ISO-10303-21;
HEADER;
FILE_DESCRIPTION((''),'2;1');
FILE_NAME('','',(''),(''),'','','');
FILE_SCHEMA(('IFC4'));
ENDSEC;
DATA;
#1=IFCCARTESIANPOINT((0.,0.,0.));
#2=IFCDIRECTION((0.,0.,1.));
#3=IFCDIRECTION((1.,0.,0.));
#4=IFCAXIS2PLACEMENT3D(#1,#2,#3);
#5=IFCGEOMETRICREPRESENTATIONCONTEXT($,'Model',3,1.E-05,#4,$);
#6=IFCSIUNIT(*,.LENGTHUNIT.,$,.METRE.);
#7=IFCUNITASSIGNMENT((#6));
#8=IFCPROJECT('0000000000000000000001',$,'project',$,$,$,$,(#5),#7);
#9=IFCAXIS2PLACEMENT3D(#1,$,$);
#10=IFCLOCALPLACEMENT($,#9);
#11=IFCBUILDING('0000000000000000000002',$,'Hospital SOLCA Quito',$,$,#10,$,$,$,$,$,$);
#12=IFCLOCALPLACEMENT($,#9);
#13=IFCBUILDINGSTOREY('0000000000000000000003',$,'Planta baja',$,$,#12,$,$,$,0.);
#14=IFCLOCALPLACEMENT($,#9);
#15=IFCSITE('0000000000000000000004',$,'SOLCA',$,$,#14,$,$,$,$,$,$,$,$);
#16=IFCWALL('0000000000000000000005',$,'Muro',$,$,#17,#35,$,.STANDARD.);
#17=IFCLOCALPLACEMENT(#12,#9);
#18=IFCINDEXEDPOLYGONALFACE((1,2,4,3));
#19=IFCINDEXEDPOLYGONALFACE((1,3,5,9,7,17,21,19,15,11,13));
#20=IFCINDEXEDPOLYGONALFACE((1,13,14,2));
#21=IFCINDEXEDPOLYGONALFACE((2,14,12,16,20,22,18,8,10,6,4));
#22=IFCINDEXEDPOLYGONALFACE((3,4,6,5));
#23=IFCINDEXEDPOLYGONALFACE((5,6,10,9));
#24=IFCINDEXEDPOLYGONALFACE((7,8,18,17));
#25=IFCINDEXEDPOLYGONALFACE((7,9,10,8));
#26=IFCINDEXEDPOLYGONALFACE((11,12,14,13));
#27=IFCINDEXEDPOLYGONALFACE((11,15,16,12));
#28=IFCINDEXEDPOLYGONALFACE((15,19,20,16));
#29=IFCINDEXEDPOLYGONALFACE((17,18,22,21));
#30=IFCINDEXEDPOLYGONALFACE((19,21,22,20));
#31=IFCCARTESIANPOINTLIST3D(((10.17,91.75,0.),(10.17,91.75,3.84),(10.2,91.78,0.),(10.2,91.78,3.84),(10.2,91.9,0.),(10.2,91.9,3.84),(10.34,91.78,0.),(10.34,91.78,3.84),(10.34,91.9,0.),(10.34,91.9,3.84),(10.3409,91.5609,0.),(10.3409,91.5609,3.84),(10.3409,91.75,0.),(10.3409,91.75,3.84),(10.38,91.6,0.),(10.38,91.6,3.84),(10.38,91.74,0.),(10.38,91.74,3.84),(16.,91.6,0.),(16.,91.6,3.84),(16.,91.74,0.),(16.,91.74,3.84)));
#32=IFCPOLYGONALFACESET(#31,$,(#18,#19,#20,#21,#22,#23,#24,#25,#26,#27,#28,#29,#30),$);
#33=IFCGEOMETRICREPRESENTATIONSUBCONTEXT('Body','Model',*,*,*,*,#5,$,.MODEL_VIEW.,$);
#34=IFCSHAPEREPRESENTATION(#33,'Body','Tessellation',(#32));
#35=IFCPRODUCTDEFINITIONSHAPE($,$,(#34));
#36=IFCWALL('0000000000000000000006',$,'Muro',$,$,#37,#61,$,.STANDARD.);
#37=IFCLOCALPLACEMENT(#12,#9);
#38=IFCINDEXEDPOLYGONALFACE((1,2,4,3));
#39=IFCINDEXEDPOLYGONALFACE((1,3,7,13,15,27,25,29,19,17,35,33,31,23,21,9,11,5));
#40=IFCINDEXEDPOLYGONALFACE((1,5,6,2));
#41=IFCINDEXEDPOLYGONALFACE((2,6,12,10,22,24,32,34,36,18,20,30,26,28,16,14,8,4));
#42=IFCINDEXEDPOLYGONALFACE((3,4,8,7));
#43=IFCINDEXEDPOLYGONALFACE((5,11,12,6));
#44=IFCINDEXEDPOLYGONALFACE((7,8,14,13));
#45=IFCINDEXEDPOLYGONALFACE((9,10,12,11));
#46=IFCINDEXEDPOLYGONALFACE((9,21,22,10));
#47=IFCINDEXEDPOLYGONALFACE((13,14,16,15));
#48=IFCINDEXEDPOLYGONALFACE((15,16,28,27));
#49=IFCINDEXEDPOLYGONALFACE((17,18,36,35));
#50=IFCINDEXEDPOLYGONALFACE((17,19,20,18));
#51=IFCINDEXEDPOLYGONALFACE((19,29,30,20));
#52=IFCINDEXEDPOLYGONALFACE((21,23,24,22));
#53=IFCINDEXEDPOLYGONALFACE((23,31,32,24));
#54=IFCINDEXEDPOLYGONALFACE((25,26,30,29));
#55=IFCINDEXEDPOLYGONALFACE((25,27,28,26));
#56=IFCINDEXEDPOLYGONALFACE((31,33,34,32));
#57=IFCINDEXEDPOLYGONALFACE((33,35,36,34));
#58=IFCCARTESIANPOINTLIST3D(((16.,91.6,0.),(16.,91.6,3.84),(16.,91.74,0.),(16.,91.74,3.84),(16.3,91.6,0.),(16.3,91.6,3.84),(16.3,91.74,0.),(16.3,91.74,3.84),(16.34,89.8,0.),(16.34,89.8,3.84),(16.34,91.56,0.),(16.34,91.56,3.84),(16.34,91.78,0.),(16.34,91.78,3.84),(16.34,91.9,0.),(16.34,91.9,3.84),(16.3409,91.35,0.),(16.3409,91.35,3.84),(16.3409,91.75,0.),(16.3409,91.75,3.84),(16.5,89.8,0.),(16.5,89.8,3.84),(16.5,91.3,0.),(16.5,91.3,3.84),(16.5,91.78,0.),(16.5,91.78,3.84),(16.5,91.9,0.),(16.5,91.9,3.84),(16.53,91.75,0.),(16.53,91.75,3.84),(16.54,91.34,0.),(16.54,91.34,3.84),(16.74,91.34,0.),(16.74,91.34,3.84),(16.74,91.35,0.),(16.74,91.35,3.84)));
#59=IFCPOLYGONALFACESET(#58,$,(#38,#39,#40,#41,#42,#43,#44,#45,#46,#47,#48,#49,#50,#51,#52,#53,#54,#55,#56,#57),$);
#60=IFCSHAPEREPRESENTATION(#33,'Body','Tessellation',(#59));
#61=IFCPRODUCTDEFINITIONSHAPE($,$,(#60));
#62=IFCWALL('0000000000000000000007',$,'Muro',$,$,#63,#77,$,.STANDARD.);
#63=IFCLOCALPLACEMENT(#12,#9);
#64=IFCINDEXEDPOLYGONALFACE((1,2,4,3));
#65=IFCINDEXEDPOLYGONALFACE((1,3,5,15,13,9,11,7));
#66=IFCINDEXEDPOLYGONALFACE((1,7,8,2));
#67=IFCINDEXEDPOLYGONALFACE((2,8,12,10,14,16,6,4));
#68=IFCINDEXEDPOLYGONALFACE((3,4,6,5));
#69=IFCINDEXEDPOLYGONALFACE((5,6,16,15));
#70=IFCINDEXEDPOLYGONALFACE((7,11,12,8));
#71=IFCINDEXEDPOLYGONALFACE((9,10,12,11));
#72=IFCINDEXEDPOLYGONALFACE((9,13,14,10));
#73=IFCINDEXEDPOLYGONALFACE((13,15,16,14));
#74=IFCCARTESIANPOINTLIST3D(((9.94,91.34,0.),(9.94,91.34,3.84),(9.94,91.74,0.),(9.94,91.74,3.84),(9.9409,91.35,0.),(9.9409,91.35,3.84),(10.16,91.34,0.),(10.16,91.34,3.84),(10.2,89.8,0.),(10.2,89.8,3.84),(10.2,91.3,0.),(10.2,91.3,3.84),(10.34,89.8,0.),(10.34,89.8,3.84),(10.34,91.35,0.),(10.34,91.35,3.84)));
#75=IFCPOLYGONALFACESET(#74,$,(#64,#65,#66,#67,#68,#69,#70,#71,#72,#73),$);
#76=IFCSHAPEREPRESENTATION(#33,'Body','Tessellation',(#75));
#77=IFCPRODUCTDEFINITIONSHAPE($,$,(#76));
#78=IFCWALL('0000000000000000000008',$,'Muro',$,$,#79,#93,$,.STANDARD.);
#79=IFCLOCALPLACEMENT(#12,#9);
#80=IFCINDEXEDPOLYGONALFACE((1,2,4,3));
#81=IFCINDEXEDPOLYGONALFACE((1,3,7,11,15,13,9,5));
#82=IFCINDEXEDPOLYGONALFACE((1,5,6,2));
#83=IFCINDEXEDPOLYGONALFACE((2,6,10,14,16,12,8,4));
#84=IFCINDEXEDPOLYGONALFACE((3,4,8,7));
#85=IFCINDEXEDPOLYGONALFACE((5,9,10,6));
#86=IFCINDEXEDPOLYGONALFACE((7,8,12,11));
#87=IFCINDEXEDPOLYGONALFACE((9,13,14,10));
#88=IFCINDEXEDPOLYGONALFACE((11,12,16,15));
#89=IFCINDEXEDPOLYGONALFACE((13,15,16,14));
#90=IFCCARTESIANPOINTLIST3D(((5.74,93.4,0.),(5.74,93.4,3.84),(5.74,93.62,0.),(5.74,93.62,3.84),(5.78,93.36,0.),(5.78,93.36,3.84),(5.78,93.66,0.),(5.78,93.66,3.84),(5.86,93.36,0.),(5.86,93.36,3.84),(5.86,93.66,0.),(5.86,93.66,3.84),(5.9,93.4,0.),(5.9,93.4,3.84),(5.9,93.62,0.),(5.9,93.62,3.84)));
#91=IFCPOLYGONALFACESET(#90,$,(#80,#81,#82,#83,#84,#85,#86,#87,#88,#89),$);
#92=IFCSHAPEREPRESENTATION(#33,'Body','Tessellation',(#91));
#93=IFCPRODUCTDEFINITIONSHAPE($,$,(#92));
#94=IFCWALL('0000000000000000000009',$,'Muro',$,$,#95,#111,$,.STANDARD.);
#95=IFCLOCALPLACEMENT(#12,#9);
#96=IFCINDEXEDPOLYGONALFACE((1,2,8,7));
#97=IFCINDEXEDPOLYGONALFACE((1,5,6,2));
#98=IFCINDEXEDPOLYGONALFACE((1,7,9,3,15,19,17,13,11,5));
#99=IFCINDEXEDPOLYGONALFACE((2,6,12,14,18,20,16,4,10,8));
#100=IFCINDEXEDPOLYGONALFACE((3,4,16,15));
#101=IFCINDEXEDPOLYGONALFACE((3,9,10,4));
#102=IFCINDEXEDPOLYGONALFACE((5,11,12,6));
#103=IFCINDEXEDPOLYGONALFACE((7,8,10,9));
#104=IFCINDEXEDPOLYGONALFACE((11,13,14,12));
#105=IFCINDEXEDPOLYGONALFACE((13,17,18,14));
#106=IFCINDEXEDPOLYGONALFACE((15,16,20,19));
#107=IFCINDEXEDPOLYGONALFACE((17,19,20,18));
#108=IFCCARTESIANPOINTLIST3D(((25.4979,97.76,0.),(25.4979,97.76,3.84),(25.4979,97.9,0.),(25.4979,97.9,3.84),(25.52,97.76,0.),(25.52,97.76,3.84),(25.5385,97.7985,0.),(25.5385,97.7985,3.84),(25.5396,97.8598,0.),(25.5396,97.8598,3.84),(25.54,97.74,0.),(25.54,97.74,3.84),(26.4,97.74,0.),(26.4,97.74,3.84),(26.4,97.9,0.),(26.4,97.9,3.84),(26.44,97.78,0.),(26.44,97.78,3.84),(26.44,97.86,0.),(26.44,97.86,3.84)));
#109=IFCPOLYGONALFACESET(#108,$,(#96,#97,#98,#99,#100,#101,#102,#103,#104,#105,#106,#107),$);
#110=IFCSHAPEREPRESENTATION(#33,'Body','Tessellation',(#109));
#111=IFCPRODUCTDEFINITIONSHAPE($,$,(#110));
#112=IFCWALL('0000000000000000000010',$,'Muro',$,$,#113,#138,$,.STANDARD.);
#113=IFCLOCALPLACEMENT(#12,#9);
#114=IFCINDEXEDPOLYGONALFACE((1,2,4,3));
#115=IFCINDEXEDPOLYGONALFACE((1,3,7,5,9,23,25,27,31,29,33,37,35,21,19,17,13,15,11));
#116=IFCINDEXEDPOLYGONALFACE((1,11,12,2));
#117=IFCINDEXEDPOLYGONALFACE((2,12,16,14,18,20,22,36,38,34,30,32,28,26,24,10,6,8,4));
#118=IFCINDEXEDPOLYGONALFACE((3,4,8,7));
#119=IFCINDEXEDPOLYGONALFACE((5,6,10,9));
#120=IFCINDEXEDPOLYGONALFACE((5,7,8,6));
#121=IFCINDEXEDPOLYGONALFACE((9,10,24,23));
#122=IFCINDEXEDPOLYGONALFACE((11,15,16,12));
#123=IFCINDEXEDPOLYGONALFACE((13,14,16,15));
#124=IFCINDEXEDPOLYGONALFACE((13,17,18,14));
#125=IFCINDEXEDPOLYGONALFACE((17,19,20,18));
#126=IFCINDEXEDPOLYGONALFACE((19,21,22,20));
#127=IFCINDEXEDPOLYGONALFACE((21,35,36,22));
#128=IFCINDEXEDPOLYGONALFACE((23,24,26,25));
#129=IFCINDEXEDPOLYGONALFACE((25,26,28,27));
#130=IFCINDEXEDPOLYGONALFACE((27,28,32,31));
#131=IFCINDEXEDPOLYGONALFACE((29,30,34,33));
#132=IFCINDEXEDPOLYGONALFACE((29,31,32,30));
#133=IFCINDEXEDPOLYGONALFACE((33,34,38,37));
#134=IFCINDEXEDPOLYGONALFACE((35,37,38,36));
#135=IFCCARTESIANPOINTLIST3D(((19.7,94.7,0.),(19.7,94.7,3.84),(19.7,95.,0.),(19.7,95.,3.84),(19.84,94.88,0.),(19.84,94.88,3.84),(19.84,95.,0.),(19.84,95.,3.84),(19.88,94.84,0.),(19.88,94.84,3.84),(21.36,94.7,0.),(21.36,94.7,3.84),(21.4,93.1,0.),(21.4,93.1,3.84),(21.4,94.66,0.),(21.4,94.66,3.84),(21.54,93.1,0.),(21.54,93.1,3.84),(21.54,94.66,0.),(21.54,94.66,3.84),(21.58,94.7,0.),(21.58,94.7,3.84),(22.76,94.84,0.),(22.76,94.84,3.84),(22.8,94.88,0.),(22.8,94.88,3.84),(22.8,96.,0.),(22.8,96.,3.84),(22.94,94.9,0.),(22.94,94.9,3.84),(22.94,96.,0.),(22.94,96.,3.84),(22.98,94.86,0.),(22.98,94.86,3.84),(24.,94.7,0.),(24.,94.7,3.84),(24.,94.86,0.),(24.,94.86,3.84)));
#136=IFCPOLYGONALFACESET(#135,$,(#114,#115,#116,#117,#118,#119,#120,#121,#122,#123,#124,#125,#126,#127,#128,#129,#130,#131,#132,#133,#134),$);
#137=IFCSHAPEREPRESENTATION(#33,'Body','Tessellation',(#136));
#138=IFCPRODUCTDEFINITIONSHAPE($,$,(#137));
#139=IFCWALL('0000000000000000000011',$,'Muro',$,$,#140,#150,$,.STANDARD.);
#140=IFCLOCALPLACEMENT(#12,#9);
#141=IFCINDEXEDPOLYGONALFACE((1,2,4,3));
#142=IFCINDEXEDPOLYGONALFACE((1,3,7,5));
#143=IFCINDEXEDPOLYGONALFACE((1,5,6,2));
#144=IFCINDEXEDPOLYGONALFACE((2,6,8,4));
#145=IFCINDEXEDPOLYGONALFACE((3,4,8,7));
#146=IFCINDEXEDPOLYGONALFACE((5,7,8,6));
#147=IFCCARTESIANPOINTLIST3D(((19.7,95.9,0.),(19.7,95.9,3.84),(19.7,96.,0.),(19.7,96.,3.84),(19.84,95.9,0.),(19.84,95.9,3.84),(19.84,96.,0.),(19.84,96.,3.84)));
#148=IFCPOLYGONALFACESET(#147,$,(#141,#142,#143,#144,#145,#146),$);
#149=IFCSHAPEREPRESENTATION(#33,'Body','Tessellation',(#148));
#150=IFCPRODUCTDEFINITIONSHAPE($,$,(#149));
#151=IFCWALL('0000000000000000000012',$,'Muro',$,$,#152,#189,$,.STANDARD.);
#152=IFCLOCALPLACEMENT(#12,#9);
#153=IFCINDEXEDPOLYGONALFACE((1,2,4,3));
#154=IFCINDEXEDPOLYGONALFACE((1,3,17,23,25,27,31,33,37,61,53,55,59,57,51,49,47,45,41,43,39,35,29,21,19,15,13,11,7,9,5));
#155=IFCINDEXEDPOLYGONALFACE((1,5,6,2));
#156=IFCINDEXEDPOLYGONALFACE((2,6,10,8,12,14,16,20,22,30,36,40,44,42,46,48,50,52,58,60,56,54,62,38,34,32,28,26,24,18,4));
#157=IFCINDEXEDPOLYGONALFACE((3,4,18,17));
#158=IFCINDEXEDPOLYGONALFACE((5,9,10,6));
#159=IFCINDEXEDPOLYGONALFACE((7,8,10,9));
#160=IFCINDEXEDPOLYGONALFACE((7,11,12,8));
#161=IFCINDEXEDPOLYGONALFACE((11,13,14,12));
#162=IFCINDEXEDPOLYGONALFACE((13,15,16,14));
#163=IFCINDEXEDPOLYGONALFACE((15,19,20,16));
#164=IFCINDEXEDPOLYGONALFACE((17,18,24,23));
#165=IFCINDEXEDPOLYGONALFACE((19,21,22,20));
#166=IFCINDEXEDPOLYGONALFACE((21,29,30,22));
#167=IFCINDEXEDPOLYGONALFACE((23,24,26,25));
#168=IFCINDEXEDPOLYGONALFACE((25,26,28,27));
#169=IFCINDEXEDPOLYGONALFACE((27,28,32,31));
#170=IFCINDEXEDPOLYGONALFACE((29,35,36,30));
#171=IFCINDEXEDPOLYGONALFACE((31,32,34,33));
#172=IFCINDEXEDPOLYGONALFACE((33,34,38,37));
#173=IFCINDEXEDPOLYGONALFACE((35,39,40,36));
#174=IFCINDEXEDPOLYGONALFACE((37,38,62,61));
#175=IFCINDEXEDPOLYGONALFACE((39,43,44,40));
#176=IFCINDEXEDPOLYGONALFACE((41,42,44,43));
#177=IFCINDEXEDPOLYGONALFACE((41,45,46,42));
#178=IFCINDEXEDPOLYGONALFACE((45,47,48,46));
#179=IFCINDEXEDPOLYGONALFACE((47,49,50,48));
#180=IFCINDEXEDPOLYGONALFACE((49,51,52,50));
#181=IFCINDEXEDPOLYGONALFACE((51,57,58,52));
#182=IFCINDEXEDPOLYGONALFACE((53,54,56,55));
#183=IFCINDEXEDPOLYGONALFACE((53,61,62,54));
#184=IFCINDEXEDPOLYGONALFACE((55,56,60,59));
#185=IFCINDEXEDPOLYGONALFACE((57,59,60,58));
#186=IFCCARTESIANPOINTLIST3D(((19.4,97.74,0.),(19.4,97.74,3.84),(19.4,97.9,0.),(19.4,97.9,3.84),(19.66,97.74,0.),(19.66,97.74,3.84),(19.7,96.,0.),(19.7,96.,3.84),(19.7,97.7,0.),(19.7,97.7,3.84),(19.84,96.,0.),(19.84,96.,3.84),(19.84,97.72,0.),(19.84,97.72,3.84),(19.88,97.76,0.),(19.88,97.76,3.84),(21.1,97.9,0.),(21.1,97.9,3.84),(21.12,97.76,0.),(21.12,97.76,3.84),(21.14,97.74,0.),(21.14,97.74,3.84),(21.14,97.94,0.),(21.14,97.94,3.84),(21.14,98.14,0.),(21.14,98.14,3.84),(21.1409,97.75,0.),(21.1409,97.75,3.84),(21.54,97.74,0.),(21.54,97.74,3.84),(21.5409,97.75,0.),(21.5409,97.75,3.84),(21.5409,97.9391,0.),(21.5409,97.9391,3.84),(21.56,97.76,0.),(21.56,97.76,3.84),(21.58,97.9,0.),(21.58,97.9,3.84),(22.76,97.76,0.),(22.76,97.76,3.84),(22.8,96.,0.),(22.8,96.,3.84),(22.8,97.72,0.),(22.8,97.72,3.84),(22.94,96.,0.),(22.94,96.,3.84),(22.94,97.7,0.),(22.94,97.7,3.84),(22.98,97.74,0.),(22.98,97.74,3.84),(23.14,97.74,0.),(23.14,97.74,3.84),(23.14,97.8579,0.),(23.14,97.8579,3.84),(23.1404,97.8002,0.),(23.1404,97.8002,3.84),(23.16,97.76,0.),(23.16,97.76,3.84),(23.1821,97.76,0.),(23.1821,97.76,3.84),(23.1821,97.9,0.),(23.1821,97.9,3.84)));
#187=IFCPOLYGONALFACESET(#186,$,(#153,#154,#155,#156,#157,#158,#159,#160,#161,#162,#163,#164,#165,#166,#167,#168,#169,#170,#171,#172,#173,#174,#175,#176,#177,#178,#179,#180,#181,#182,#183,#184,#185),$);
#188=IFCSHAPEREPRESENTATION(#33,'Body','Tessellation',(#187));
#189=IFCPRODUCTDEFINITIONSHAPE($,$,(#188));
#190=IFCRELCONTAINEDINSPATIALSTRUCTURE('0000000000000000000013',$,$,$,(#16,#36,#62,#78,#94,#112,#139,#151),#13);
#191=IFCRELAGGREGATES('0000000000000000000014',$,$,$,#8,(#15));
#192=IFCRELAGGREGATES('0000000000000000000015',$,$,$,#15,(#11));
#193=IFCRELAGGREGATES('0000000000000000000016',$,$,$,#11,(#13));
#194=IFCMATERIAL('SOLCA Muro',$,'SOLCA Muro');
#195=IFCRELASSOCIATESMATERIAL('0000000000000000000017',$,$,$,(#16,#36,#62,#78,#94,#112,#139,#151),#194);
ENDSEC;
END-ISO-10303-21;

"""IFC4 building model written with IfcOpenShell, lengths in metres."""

from ifc_helpers import new_model, si_unit, origin, origin_with_axes, place, context, subcontext, project, spatial, polyline, outline, extrude, material, element, save


model = new_model("IFC4")

# Units and contexts
model_context = context("Model", 3, precision=1e-05, world=origin_with_axes())
body_context = subcontext(model_context, "Body", "Model", "MODEL_VIEW")
ifc_project = project(units=[si_unit("LENGTHUNIT", "METRE")], contexts=[model_context])

# Site, building, storey
site_placement = place(None, origin())
site = spatial("IfcSite", under=ifc_project, at=site_placement, Name="SOLCA")
building_placement = place(None, origin())
building = spatial("IfcBuilding", under=site, at=building_placement, Name="Hospital SOLCA Quito")
storey_placement = place(None, origin())
storey = spatial("IfcBuildingStorey", under=building, at=storey_placement, Name="Planta baja", Elevation=0.0)

# Walls
ifc_material = material(Name="SOLCA Muro", Category="SOLCA Muro")
wall_1_placement = place(storey_placement, origin_with_axes())
element("IfcWall", 1, at=wall_1_placement, inside=storey, material=ifc_material, Name="Muro", PredefinedType="STANDARD", context=body_context, shape_type="SweptSolid", body=[
    extrude(outline(polyline([(10.38, 91.6), (10.3409, 91.5609), (10.3409, 91.75), (10.17, 91.75), (10.2, 91.78), (10.2, 91.9), (10.34, 91.9), (10.34, 91.78), (10.38, 91.74), (16.0, 91.74), (16.0, 91.6), (10.38, 91.6)])), origin_with_axes(), (0.0, 0.0, 1.0), 3.84),
])
wall_2_placement = place(storey_placement, origin_with_axes())
element("IfcWall", 2, at=wall_2_placement, inside=storey, material=ifc_material, Name="Muro", PredefinedType="STANDARD", context=body_context, shape_type="SweptSolid", body=[
    extrude(outline(polyline([(16.3, 91.6), (16.0, 91.6), (16.0, 91.74), (16.3, 91.74), (16.34, 91.78), (16.34, 91.9), (16.5, 91.9), (16.5, 91.78), (16.53, 91.75), (16.3409, 91.75), (16.3409, 91.35), (16.74, 91.35), (16.74, 91.34), (16.54, 91.34), (16.5, 91.3), (16.5, 89.8), (16.34, 89.8), (16.34, 91.56), (16.3, 91.6)])), origin_with_axes(), (0.0, 0.0, 1.0), 3.84),
])
wall_3_placement = place(storey_placement, origin_with_axes())
element("IfcWall", 3, at=wall_3_placement, inside=storey, material=ifc_material, Name="Muro", PredefinedType="STANDARD", context=body_context, shape_type="SweptSolid", body=[
    extrude(outline(polyline([(10.2, 91.3), (10.16, 91.34), (9.94, 91.34), (9.94, 91.74), (9.9409, 91.35), (10.34, 91.35), (10.34, 89.8), (10.2, 89.8), (10.2, 91.3)])), origin_with_axes(), (0.0, 0.0, 1.0), 3.84),
])
wall_4_placement = place(storey_placement, origin_with_axes())
element("IfcWall", 4, at=wall_4_placement, inside=storey, material=ifc_material, Name="Muro", PredefinedType="STANDARD", context=body_context, shape_type="SweptSolid", body=[
    extrude(outline(polyline([(5.9, 93.4), (5.86, 93.36), (5.78, 93.36), (5.74, 93.4), (5.74, 93.62), (5.78, 93.66), (5.86, 93.66), (5.9, 93.62), (5.9, 93.4)])), origin_with_axes(), (0.0, 0.0, 1.0), 3.84),
])
wall_5_placement = place(storey_placement, origin_with_axes())
element("IfcWall", 5, at=wall_5_placement, inside=storey, material=ifc_material, Name="Muro", PredefinedType="STANDARD", context=body_context, shape_type="SweptSolid", body=[
    extrude(outline(polyline([(25.5385, 97.7985), (25.5396, 97.8598), (25.4979, 97.9), (26.4, 97.9), (26.44, 97.86), (26.44, 97.78), (26.4, 97.74), (25.54, 97.74), (25.52, 97.76), (25.4979, 97.76), (25.5385, 97.7985)])), origin_with_axes(), (0.0, 0.0, 1.0), 3.84),
])
wall_6_placement = place(storey_placement, origin_with_axes())
element("IfcWall", 6, at=wall_6_placement, inside=storey, material=ifc_material, Name="Muro", PredefinedType="STANDARD", context=body_context, shape_type="SweptSolid", body=[
    extrude(outline(polyline([(21.58, 94.7), (21.54, 94.66), (21.54, 93.1), (21.4, 93.1), (21.4, 94.66), (21.36, 94.7), (19.7, 94.7), (19.7, 95.0), (19.84, 95.0), (19.84, 94.88), (19.88, 94.84), (22.76, 94.84), (22.8, 94.88), (22.8, 96.0), (22.94, 96.0), (22.94, 94.9), (22.98, 94.86), (24.0, 94.86), (24.0, 94.7), (21.58, 94.7)])), origin_with_axes(), (0.0, 0.0, 1.0), 3.84),
])
wall_7_placement = place(storey_placement, origin_with_axes())
element("IfcWall", 7, at=wall_7_placement, inside=storey, material=ifc_material, Name="Muro", PredefinedType="STANDARD", context=body_context, shape_type="SweptSolid", body=[
    extrude(outline(polyline([(19.84, 95.9), (19.7, 95.9), (19.7, 96.0), (19.84, 96.0), (19.84, 95.9)])), origin_with_axes(), (0.0, 0.0, 1.0), 3.84),
])
wall_8_placement = place(storey_placement, origin_with_axes())
element("IfcWall", 8, at=wall_8_placement, inside=storey, material=ifc_material, Name="Muro", PredefinedType="STANDARD", context=body_context, shape_type="SweptSolid", body=[
    extrude(outline(polyline([(22.8, 97.72), (22.76, 97.76), (21.56, 97.76), (21.54, 97.74), (21.14, 97.74), (21.12, 97.76), (19.88, 97.76), (19.84, 97.72), (19.84, 96.0), (19.7, 96.0), (19.7, 97.7), (19.66, 97.74), (19.4, 97.74), (19.4, 97.9), (21.1, 97.9), (21.14, 97.94), (21.14, 98.14), (21.1409, 97.75), (21.5409, 97.75), (21.5409, 97.9391), (21.58, 97.9), (23.1821, 97.9), (23.14, 97.8579), (23.1404, 97.8002), (23.1821, 97.76), (23.16, 97.76), (23.14, 97.74), (22.98, 97.74), (22.94, 97.7), (22.94, 96.0), (22.8, 96.0), (22.8, 97.72)])), origin_with_axes(), (0.0, 0.0, 1.0), 3.84),
])

save(model, "model.ifc")
